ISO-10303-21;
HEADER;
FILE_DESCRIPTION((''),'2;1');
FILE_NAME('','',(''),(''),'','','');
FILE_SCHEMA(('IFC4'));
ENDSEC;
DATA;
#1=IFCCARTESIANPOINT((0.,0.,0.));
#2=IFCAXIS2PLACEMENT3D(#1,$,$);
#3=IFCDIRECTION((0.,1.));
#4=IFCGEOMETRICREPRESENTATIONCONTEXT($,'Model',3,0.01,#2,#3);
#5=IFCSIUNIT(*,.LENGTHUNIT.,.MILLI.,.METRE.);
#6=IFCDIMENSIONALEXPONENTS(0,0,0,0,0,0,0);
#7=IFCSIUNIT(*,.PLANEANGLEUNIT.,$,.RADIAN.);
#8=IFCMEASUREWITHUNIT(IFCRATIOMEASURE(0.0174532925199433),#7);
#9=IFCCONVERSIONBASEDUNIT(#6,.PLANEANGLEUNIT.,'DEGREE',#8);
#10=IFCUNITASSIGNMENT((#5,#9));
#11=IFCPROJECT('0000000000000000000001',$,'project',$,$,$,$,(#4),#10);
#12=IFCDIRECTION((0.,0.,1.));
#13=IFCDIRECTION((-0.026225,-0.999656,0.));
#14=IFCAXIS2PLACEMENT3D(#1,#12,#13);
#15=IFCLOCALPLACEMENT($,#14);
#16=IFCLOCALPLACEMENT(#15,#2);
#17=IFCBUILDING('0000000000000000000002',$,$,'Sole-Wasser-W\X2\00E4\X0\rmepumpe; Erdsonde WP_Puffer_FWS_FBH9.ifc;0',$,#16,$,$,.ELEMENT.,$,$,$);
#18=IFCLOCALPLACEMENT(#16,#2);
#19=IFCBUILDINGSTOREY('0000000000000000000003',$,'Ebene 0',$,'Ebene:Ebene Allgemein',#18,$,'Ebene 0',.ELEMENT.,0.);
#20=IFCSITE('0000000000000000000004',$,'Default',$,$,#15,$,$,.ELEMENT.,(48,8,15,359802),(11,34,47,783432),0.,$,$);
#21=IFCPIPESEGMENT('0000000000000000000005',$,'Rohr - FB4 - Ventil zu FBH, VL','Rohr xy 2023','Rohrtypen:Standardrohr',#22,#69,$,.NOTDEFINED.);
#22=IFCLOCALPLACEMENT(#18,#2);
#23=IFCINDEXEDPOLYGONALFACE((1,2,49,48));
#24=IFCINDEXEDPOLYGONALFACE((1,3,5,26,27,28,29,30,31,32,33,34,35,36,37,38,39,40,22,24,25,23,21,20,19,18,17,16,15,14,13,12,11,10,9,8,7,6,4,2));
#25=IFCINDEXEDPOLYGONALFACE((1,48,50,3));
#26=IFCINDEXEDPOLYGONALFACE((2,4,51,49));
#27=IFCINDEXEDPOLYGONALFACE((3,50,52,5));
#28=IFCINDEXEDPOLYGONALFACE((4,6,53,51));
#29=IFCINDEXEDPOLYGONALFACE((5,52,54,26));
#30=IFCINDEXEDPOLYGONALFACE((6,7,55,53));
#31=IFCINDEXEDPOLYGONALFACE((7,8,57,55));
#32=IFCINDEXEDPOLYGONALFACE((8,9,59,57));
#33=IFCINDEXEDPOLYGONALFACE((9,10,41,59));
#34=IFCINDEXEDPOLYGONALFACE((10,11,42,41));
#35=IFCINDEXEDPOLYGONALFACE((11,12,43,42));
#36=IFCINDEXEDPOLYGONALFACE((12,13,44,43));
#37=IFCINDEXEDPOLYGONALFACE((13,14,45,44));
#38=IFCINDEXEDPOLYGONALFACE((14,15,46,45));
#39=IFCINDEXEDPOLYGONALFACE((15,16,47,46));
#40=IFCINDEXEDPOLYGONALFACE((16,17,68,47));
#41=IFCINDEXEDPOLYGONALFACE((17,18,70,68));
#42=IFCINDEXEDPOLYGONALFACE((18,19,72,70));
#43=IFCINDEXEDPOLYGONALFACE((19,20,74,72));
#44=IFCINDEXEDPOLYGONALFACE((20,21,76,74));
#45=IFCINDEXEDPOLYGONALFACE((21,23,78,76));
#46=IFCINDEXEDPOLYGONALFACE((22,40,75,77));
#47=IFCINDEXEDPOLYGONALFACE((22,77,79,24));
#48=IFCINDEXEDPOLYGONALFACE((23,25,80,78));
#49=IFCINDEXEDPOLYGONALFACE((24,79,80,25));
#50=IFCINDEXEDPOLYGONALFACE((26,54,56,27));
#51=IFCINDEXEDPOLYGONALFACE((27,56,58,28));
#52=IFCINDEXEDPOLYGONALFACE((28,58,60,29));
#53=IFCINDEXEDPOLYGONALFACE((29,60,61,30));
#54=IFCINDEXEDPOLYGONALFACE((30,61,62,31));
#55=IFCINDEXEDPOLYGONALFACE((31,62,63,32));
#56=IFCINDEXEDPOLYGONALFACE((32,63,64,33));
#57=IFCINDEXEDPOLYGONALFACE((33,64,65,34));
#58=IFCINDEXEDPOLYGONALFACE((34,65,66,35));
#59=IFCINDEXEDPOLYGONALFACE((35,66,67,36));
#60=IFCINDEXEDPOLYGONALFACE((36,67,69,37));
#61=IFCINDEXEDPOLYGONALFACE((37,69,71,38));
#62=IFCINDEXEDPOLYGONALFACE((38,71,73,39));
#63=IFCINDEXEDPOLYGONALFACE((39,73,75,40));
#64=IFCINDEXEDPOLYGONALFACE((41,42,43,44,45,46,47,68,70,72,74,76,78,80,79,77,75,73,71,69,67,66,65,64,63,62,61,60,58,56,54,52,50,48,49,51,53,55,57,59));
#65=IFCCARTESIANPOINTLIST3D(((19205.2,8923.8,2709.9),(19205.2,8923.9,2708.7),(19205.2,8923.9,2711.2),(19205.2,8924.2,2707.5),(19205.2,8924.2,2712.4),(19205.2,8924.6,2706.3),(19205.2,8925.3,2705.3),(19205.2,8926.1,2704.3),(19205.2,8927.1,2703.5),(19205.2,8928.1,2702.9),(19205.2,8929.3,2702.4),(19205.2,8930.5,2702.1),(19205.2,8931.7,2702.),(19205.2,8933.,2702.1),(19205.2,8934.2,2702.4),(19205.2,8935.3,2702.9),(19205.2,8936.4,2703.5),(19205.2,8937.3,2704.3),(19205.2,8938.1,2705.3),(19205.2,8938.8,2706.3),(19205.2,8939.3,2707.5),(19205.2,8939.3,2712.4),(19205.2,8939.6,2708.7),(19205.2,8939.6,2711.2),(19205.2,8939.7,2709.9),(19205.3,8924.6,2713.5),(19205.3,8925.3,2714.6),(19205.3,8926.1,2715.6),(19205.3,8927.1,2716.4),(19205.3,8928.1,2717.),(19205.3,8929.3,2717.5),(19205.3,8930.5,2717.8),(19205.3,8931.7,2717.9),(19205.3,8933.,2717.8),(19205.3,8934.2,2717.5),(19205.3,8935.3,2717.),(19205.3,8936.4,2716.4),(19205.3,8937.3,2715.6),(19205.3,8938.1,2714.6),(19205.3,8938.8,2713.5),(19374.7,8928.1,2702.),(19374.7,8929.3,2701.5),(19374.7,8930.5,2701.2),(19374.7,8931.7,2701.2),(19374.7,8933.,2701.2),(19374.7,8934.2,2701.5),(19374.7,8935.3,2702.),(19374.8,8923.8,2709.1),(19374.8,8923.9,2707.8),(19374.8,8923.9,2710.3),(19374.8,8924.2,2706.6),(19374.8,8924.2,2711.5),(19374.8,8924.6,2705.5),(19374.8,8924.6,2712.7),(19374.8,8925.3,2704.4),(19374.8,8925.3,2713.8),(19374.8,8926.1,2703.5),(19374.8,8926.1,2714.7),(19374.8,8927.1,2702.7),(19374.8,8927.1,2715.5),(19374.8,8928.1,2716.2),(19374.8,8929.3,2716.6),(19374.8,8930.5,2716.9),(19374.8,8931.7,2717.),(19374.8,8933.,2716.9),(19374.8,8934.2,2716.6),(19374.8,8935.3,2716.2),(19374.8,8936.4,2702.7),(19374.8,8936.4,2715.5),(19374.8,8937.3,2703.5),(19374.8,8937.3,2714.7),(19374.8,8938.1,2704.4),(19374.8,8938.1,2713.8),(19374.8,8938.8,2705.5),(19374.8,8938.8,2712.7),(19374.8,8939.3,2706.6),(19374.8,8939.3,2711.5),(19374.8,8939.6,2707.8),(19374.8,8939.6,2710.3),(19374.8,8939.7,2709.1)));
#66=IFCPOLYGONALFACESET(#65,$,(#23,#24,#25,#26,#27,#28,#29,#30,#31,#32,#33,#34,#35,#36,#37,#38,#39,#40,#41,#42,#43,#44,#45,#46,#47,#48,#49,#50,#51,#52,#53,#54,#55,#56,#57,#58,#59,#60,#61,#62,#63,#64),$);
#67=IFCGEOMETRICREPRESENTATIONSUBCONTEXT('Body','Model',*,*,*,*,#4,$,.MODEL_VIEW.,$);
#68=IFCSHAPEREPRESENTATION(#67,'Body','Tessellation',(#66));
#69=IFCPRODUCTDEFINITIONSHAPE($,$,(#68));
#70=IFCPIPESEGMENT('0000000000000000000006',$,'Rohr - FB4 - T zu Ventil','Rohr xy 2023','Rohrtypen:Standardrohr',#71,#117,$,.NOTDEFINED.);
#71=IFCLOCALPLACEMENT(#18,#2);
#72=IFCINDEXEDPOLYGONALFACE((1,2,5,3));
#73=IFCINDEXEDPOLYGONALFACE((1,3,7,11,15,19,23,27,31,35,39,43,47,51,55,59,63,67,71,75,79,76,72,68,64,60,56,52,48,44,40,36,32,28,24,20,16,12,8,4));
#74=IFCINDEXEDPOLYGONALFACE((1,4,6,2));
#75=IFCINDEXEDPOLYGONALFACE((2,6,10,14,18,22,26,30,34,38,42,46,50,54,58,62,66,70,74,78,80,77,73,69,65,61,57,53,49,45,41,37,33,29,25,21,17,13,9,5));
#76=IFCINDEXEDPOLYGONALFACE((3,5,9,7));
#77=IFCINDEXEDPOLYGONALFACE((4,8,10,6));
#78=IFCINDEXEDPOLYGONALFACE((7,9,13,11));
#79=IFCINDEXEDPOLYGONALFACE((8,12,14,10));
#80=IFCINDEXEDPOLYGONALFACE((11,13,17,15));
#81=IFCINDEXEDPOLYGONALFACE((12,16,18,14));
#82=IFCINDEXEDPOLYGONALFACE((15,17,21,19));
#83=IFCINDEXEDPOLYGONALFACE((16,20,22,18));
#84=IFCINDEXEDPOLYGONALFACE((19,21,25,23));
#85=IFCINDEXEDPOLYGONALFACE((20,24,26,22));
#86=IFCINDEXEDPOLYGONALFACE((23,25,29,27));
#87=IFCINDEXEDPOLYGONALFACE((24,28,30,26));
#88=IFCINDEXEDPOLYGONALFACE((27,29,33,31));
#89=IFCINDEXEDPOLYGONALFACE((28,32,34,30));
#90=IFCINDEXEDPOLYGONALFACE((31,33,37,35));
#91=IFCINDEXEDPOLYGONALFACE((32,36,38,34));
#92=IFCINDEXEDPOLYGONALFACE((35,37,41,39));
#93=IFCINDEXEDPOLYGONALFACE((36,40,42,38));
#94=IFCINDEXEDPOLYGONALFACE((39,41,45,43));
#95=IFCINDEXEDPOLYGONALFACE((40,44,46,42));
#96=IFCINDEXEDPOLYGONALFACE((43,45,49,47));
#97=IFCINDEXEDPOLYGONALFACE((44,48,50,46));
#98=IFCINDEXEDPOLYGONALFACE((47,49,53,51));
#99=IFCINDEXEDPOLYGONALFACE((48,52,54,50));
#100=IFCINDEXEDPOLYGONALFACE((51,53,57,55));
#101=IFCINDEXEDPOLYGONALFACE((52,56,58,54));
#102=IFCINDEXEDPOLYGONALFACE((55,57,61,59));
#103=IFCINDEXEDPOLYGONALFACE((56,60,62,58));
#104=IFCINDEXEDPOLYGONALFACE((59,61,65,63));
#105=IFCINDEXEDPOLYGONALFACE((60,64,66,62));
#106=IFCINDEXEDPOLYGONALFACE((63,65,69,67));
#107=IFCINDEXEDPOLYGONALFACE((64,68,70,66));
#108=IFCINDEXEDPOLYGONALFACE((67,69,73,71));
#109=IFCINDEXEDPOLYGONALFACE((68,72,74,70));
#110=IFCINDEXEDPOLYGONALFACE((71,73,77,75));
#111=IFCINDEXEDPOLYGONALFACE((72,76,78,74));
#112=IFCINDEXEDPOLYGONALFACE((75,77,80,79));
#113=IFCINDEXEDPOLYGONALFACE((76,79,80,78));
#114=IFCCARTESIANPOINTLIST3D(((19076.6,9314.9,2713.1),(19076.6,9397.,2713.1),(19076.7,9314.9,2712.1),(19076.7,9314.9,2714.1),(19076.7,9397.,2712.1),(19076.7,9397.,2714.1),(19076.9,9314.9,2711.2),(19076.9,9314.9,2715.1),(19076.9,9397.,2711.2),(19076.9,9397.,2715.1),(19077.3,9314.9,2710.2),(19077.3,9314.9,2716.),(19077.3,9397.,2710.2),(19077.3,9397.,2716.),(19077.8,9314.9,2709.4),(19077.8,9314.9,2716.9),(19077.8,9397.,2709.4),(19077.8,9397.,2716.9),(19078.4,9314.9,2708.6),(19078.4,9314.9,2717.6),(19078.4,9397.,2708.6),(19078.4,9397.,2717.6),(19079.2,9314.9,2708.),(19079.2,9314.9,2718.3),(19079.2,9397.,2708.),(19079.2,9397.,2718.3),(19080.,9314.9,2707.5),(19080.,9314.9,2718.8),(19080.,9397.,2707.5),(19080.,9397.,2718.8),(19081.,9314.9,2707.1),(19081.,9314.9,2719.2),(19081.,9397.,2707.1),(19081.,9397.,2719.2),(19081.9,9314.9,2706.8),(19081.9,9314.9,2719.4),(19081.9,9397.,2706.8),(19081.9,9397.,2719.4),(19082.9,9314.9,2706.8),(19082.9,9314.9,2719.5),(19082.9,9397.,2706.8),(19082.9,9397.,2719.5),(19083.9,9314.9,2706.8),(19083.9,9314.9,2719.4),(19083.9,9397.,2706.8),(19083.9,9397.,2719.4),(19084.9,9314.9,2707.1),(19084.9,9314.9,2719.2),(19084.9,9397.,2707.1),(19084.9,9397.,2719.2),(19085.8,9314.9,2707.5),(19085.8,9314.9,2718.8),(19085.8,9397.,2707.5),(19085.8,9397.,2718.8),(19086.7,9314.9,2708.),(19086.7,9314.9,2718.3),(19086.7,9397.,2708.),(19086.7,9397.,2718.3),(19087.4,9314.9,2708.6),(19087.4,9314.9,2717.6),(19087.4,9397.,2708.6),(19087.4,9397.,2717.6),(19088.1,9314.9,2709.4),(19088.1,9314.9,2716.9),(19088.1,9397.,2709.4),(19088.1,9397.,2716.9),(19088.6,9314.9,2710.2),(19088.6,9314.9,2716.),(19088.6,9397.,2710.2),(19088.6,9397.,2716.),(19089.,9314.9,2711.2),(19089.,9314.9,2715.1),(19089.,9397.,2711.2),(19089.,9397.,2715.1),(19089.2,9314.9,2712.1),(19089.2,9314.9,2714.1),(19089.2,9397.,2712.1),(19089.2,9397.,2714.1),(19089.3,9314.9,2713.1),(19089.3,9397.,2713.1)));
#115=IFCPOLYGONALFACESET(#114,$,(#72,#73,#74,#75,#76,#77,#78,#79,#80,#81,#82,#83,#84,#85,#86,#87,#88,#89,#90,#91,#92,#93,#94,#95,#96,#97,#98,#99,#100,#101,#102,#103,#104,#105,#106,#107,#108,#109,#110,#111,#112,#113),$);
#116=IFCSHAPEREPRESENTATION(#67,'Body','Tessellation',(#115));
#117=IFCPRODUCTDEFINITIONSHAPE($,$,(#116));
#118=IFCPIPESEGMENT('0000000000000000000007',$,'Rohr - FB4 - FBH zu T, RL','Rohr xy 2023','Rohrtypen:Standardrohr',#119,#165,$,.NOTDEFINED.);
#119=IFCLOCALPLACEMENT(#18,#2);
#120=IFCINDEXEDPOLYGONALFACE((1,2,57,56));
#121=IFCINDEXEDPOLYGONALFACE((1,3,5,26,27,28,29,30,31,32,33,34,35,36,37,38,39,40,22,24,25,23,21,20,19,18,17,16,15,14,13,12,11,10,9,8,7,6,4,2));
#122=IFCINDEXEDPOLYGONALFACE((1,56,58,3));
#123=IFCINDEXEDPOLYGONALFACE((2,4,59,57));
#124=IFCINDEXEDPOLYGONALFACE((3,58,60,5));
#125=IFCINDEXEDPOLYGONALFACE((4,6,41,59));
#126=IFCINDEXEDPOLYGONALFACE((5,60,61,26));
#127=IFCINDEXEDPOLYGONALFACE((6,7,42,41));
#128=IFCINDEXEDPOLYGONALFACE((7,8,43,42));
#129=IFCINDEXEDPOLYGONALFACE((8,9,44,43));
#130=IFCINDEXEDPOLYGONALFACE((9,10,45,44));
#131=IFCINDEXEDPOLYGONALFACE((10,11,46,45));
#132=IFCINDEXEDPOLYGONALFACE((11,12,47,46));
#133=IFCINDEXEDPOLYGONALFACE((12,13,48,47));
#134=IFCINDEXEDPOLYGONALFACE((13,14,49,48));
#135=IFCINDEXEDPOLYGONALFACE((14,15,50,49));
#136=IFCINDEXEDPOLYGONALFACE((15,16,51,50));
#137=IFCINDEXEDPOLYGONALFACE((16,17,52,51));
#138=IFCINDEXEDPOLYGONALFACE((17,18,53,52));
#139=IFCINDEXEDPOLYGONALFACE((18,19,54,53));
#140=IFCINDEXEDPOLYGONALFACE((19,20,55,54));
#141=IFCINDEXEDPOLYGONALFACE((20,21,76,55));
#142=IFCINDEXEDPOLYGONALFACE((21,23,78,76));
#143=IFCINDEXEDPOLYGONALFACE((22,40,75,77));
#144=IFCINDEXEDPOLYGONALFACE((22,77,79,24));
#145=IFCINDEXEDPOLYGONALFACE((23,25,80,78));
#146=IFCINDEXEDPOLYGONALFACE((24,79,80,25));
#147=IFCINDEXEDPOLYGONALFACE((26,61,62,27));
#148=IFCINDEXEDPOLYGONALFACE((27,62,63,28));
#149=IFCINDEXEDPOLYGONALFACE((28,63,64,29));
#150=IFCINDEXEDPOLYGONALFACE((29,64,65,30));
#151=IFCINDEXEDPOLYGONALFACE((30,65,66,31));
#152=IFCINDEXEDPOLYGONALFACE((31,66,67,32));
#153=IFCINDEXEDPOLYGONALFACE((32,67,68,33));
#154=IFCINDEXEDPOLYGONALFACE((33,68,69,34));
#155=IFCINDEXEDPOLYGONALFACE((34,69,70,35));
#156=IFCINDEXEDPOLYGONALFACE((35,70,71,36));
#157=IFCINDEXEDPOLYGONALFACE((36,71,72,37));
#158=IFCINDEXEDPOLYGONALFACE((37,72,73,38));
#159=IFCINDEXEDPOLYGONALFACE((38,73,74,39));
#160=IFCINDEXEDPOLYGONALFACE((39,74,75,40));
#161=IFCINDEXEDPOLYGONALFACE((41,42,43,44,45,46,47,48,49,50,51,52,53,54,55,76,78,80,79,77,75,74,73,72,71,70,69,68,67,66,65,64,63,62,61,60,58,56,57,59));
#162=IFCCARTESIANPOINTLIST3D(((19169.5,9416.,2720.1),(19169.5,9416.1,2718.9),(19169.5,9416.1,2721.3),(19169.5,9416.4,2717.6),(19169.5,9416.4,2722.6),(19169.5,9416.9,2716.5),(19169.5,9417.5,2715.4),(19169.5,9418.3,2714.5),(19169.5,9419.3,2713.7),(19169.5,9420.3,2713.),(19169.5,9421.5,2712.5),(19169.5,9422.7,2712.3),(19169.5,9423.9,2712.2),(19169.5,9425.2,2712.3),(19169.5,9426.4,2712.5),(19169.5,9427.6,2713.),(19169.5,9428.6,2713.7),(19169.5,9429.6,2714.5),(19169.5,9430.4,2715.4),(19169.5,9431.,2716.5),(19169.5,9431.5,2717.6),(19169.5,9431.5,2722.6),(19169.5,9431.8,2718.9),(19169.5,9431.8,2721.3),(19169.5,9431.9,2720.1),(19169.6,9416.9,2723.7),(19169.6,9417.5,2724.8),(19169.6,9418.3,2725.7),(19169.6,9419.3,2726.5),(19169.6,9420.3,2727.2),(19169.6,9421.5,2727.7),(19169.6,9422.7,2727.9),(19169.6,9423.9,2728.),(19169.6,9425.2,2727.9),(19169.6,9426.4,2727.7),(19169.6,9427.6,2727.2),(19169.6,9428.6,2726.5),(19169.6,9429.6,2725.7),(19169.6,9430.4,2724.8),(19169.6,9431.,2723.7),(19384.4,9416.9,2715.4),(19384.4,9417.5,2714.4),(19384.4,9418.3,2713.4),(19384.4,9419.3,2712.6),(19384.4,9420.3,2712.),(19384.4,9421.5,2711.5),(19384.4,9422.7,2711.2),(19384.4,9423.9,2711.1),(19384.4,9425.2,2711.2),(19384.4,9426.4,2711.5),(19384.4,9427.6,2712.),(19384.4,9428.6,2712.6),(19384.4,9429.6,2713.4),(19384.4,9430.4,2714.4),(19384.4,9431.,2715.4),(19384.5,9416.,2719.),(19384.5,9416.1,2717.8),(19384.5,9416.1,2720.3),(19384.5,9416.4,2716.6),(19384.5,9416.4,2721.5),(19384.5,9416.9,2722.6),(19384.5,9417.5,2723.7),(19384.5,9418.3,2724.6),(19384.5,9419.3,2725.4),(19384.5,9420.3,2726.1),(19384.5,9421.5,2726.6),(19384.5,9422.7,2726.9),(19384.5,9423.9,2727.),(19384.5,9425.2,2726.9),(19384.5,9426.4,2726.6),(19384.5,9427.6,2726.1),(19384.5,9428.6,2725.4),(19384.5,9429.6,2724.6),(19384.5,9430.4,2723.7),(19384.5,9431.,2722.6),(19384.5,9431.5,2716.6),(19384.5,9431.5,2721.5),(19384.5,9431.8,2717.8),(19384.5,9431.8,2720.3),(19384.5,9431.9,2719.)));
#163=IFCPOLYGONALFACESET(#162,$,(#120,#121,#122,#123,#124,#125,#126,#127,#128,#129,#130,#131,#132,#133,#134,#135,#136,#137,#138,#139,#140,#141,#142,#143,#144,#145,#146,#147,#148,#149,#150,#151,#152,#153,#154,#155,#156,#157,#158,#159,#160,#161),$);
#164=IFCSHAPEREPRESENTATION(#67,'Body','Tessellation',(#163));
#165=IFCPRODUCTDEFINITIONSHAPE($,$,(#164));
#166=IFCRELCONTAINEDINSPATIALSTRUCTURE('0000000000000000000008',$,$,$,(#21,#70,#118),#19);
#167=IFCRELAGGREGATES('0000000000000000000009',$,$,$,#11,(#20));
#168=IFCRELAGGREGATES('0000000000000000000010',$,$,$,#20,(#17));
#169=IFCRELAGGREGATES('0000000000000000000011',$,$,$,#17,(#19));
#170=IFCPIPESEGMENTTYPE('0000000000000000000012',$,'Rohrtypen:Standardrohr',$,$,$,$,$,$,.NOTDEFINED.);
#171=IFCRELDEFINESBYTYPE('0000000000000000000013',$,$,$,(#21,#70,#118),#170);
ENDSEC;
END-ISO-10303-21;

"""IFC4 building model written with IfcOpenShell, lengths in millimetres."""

from ifc_helpers import new_model, entity, si_unit, converted_unit, direction, frame, origin, place, context, subcontext, project, spatial, indexed_curve, outline, extrude, type_object, element, save


model = new_model("IFC4")

# Units and contexts
model_context = context("Model", 3, precision=0.01, world=origin(), true_north=direction((0.0, 1.0)))
body_context = subcontext(model_context, "Body", "Model", "MODEL_VIEW")
ifc_project = project(units=[si_unit("LENGTHUNIT", "METRE", prefix="MILLI"), converted_unit("PLANEANGLEUNIT", "DEGREE", entity("IfcRatioMeasure", 0.0174532925199433), si_unit("PLANEANGLEUNIT", "RADIAN"), dimensions=[0, 0, 0, 0, 0, 0, 0])], contexts=[model_context])

# Site, building, storey
site_placement = place(None, frame((0.0, 0.0, 0.0), z_axis=(0.0, 0.0, 1.0), x_axis=(-0.026225, -0.999656, 0.0)))
site = spatial("IfcSite", under=ifc_project, at=site_placement, Name="Default", CompositionType="ELEMENT", RefLatitude=(48, 8, 15, 359802), RefLongitude=(11, 34, 47, 783432), RefElevation=0.0)
building_placement = place(site_placement, origin())
building = spatial("IfcBuilding", under=site, at=building_placement, Description="Sole-Wasser-Wärmepumpe; Erdsonde WP_Puffer_FWS_FBH9.ifc;0", CompositionType="ELEMENT")
storey_placement = place(building_placement, origin())
storey = spatial("IfcBuildingStorey", under=building, at=storey_placement, Name="Ebene 0", ObjectType="Ebene:Ebene Allgemein", LongName="Ebene 0", CompositionType="ELEMENT", Elevation=0.0)

# Pipe segments
pipe_segment_type = type_object("IfcPipeSegmentType", Name="Rohrtypen:Standardrohr", PredefinedType="NOTDEFINED")
pipe_segment_1_placement = place(storey_placement, origin())
element("IfcPipeSegment", 1, at=pipe_segment_1_placement, inside=storey, type_object=pipe_segment_type, Name="Rohr - FB4 - Ventil zu FBH, VL", Description="Rohr xy 2023", ObjectType="Rohrtypen:Standardrohr", PredefinedType="NOTDEFINED", context=body_context, shape_type="SweptSolid", body=[
    extrude(outline(indexed_curve([(7.9, 0.0), (7.8, 1.2), (7.6, 2.5), (7.1, 3.6), (6.4, 4.7), (5.6, 5.6), (4.7, 6.4), (3.6, 7.1), (2.5, 7.6), (1.2, 7.8), (0.0, 7.9), (-1.2, 7.8), (-2.5, 7.6), (-3.6, 7.1), (-4.7, 6.4), (-5.6, 5.6), (-6.4, 4.7), (-7.1, 3.6), (-7.6, 2.5), (-7.8, 1.2), (-7.9, 0.0), (-7.8, -1.2), (-7.6, -2.5), (-7.1, -3.6), (-6.4, -4.7), (-5.6, -5.6), (-4.7, -6.4), (-3.6, -7.1), (-2.5, -7.6), (-1.2, -7.8), (0.0, -7.9), (1.2, -7.8), (2.5, -7.6), (3.6, -7.1), (4.7, -6.4), (5.6, -5.6), (6.4, -4.7), (7.1, -3.6), (7.6, -2.5), (7.8, -1.2), (7.9, 0.0)], self_intersect=False)), frame((19205.2, 8931.7, 2709.9), z_axis=(0.999988, 0.0, -0.005), x_axis=(0.0, 1.0, 0.0)), (0.0, 0.0, 1.0), 169.5),
])
pipe_segment_2_placement = place(storey_placement, origin())
element("IfcPipeSegment", 2, at=pipe_segment_2_placement, inside=storey, type_object=pipe_segment_type, Name="Rohr - FB4 - T zu Ventil", Description="Rohr xy 2023", ObjectType="Rohrtypen:Standardrohr", PredefinedType="NOTDEFINED", context=body_context, shape_type="SweptSolid", body=[
    extrude(outline(indexed_curve([(6.4, 0.0), (6.3, 1.0), (6.0, 2.0), (5.7, 2.9), (5.1, 3.7), (4.5, 4.5), (3.7, 5.1), (2.9, 5.7), (2.0, 6.0), (1.0, 6.3), (0.0, 6.4), (-1.0, 6.3), (-2.0, 6.0), (-2.9, 5.7), (-3.7, 5.1), (-4.5, 4.5), (-5.1, 3.7), (-5.7, 2.9), (-6.0, 2.0), (-6.3, 1.0), (-6.4, 0.0), (-6.3, -1.0), (-6.0, -2.0), (-5.7, -2.9), (-5.1, -3.7), (-4.5, -4.5), (-3.7, -5.1), (-2.9, -5.7), (-2.0, -6.0), (-1.0, -6.3), (0.0, -6.4), (1.0, -6.3), (2.0, -6.0), (2.9, -5.7), (3.7, -5.1), (4.5, -4.5), (5.1, -3.7), (5.7, -2.9), (6.0, -2.0), (6.3, -1.0), (6.4, 0.0)], self_intersect=False)), frame((19082.9, 9314.9, 2713.1), z_axis=(0.0, 1.0, 0.0), x_axis=(-1.0, 0.0, 0.0)), (0.0, 0.0, 1.0), 82.2),
])
pipe_segment_3_placement = place(storey_placement, origin())
element("IfcPipeSegment", 3, at=pipe_segment_3_placement, inside=storey, type_object=pipe_segment_type, Name="Rohr - FB4 - FBH zu T, RL", Description="Rohr xy 2023", ObjectType="Rohrtypen:Standardrohr", PredefinedType="NOTDEFINED", context=body_context, shape_type="SweptSolid", body=[
    extrude(outline(indexed_curve([(7.9, 0.0), (7.8, 1.2), (7.6, 2.5), (7.1, 3.6), (6.4, 4.7), (5.6, 5.6), (4.7, 6.4), (3.6, 7.1), (2.5, 7.6), (1.2, 7.8), (0.0, 7.9), (-1.2, 7.8), (-2.5, 7.6), (-3.6, 7.1), (-4.7, 6.4), (-5.6, 5.6), (-6.4, 4.7), (-7.1, 3.6), (-7.6, 2.5), (-7.8, 1.2), (-7.9, 0.0), (-7.8, -1.2), (-7.6, -2.5), (-7.1, -3.6), (-6.4, -4.7), (-5.6, -5.6), (-4.7, -6.4), (-3.6, -7.1), (-2.5, -7.6), (-1.2, -7.8), (0.0, -7.9), (1.2, -7.8), (2.5, -7.6), (3.6, -7.1), (4.7, -6.4), (5.6, -5.6), (6.4, -4.7), (7.1, -3.6), (7.6, -2.5), (7.8, -1.2), (7.9, 0.0)], self_intersect=False)), frame((19384.5, 9423.9, 2719.0), z_axis=(-0.999988, 0.0, 0.005), x_axis=(0.0, 1.0, 0.0)), (0.0, 0.0, 1.0), 214.9),
])

save(model, "model.ifc")
